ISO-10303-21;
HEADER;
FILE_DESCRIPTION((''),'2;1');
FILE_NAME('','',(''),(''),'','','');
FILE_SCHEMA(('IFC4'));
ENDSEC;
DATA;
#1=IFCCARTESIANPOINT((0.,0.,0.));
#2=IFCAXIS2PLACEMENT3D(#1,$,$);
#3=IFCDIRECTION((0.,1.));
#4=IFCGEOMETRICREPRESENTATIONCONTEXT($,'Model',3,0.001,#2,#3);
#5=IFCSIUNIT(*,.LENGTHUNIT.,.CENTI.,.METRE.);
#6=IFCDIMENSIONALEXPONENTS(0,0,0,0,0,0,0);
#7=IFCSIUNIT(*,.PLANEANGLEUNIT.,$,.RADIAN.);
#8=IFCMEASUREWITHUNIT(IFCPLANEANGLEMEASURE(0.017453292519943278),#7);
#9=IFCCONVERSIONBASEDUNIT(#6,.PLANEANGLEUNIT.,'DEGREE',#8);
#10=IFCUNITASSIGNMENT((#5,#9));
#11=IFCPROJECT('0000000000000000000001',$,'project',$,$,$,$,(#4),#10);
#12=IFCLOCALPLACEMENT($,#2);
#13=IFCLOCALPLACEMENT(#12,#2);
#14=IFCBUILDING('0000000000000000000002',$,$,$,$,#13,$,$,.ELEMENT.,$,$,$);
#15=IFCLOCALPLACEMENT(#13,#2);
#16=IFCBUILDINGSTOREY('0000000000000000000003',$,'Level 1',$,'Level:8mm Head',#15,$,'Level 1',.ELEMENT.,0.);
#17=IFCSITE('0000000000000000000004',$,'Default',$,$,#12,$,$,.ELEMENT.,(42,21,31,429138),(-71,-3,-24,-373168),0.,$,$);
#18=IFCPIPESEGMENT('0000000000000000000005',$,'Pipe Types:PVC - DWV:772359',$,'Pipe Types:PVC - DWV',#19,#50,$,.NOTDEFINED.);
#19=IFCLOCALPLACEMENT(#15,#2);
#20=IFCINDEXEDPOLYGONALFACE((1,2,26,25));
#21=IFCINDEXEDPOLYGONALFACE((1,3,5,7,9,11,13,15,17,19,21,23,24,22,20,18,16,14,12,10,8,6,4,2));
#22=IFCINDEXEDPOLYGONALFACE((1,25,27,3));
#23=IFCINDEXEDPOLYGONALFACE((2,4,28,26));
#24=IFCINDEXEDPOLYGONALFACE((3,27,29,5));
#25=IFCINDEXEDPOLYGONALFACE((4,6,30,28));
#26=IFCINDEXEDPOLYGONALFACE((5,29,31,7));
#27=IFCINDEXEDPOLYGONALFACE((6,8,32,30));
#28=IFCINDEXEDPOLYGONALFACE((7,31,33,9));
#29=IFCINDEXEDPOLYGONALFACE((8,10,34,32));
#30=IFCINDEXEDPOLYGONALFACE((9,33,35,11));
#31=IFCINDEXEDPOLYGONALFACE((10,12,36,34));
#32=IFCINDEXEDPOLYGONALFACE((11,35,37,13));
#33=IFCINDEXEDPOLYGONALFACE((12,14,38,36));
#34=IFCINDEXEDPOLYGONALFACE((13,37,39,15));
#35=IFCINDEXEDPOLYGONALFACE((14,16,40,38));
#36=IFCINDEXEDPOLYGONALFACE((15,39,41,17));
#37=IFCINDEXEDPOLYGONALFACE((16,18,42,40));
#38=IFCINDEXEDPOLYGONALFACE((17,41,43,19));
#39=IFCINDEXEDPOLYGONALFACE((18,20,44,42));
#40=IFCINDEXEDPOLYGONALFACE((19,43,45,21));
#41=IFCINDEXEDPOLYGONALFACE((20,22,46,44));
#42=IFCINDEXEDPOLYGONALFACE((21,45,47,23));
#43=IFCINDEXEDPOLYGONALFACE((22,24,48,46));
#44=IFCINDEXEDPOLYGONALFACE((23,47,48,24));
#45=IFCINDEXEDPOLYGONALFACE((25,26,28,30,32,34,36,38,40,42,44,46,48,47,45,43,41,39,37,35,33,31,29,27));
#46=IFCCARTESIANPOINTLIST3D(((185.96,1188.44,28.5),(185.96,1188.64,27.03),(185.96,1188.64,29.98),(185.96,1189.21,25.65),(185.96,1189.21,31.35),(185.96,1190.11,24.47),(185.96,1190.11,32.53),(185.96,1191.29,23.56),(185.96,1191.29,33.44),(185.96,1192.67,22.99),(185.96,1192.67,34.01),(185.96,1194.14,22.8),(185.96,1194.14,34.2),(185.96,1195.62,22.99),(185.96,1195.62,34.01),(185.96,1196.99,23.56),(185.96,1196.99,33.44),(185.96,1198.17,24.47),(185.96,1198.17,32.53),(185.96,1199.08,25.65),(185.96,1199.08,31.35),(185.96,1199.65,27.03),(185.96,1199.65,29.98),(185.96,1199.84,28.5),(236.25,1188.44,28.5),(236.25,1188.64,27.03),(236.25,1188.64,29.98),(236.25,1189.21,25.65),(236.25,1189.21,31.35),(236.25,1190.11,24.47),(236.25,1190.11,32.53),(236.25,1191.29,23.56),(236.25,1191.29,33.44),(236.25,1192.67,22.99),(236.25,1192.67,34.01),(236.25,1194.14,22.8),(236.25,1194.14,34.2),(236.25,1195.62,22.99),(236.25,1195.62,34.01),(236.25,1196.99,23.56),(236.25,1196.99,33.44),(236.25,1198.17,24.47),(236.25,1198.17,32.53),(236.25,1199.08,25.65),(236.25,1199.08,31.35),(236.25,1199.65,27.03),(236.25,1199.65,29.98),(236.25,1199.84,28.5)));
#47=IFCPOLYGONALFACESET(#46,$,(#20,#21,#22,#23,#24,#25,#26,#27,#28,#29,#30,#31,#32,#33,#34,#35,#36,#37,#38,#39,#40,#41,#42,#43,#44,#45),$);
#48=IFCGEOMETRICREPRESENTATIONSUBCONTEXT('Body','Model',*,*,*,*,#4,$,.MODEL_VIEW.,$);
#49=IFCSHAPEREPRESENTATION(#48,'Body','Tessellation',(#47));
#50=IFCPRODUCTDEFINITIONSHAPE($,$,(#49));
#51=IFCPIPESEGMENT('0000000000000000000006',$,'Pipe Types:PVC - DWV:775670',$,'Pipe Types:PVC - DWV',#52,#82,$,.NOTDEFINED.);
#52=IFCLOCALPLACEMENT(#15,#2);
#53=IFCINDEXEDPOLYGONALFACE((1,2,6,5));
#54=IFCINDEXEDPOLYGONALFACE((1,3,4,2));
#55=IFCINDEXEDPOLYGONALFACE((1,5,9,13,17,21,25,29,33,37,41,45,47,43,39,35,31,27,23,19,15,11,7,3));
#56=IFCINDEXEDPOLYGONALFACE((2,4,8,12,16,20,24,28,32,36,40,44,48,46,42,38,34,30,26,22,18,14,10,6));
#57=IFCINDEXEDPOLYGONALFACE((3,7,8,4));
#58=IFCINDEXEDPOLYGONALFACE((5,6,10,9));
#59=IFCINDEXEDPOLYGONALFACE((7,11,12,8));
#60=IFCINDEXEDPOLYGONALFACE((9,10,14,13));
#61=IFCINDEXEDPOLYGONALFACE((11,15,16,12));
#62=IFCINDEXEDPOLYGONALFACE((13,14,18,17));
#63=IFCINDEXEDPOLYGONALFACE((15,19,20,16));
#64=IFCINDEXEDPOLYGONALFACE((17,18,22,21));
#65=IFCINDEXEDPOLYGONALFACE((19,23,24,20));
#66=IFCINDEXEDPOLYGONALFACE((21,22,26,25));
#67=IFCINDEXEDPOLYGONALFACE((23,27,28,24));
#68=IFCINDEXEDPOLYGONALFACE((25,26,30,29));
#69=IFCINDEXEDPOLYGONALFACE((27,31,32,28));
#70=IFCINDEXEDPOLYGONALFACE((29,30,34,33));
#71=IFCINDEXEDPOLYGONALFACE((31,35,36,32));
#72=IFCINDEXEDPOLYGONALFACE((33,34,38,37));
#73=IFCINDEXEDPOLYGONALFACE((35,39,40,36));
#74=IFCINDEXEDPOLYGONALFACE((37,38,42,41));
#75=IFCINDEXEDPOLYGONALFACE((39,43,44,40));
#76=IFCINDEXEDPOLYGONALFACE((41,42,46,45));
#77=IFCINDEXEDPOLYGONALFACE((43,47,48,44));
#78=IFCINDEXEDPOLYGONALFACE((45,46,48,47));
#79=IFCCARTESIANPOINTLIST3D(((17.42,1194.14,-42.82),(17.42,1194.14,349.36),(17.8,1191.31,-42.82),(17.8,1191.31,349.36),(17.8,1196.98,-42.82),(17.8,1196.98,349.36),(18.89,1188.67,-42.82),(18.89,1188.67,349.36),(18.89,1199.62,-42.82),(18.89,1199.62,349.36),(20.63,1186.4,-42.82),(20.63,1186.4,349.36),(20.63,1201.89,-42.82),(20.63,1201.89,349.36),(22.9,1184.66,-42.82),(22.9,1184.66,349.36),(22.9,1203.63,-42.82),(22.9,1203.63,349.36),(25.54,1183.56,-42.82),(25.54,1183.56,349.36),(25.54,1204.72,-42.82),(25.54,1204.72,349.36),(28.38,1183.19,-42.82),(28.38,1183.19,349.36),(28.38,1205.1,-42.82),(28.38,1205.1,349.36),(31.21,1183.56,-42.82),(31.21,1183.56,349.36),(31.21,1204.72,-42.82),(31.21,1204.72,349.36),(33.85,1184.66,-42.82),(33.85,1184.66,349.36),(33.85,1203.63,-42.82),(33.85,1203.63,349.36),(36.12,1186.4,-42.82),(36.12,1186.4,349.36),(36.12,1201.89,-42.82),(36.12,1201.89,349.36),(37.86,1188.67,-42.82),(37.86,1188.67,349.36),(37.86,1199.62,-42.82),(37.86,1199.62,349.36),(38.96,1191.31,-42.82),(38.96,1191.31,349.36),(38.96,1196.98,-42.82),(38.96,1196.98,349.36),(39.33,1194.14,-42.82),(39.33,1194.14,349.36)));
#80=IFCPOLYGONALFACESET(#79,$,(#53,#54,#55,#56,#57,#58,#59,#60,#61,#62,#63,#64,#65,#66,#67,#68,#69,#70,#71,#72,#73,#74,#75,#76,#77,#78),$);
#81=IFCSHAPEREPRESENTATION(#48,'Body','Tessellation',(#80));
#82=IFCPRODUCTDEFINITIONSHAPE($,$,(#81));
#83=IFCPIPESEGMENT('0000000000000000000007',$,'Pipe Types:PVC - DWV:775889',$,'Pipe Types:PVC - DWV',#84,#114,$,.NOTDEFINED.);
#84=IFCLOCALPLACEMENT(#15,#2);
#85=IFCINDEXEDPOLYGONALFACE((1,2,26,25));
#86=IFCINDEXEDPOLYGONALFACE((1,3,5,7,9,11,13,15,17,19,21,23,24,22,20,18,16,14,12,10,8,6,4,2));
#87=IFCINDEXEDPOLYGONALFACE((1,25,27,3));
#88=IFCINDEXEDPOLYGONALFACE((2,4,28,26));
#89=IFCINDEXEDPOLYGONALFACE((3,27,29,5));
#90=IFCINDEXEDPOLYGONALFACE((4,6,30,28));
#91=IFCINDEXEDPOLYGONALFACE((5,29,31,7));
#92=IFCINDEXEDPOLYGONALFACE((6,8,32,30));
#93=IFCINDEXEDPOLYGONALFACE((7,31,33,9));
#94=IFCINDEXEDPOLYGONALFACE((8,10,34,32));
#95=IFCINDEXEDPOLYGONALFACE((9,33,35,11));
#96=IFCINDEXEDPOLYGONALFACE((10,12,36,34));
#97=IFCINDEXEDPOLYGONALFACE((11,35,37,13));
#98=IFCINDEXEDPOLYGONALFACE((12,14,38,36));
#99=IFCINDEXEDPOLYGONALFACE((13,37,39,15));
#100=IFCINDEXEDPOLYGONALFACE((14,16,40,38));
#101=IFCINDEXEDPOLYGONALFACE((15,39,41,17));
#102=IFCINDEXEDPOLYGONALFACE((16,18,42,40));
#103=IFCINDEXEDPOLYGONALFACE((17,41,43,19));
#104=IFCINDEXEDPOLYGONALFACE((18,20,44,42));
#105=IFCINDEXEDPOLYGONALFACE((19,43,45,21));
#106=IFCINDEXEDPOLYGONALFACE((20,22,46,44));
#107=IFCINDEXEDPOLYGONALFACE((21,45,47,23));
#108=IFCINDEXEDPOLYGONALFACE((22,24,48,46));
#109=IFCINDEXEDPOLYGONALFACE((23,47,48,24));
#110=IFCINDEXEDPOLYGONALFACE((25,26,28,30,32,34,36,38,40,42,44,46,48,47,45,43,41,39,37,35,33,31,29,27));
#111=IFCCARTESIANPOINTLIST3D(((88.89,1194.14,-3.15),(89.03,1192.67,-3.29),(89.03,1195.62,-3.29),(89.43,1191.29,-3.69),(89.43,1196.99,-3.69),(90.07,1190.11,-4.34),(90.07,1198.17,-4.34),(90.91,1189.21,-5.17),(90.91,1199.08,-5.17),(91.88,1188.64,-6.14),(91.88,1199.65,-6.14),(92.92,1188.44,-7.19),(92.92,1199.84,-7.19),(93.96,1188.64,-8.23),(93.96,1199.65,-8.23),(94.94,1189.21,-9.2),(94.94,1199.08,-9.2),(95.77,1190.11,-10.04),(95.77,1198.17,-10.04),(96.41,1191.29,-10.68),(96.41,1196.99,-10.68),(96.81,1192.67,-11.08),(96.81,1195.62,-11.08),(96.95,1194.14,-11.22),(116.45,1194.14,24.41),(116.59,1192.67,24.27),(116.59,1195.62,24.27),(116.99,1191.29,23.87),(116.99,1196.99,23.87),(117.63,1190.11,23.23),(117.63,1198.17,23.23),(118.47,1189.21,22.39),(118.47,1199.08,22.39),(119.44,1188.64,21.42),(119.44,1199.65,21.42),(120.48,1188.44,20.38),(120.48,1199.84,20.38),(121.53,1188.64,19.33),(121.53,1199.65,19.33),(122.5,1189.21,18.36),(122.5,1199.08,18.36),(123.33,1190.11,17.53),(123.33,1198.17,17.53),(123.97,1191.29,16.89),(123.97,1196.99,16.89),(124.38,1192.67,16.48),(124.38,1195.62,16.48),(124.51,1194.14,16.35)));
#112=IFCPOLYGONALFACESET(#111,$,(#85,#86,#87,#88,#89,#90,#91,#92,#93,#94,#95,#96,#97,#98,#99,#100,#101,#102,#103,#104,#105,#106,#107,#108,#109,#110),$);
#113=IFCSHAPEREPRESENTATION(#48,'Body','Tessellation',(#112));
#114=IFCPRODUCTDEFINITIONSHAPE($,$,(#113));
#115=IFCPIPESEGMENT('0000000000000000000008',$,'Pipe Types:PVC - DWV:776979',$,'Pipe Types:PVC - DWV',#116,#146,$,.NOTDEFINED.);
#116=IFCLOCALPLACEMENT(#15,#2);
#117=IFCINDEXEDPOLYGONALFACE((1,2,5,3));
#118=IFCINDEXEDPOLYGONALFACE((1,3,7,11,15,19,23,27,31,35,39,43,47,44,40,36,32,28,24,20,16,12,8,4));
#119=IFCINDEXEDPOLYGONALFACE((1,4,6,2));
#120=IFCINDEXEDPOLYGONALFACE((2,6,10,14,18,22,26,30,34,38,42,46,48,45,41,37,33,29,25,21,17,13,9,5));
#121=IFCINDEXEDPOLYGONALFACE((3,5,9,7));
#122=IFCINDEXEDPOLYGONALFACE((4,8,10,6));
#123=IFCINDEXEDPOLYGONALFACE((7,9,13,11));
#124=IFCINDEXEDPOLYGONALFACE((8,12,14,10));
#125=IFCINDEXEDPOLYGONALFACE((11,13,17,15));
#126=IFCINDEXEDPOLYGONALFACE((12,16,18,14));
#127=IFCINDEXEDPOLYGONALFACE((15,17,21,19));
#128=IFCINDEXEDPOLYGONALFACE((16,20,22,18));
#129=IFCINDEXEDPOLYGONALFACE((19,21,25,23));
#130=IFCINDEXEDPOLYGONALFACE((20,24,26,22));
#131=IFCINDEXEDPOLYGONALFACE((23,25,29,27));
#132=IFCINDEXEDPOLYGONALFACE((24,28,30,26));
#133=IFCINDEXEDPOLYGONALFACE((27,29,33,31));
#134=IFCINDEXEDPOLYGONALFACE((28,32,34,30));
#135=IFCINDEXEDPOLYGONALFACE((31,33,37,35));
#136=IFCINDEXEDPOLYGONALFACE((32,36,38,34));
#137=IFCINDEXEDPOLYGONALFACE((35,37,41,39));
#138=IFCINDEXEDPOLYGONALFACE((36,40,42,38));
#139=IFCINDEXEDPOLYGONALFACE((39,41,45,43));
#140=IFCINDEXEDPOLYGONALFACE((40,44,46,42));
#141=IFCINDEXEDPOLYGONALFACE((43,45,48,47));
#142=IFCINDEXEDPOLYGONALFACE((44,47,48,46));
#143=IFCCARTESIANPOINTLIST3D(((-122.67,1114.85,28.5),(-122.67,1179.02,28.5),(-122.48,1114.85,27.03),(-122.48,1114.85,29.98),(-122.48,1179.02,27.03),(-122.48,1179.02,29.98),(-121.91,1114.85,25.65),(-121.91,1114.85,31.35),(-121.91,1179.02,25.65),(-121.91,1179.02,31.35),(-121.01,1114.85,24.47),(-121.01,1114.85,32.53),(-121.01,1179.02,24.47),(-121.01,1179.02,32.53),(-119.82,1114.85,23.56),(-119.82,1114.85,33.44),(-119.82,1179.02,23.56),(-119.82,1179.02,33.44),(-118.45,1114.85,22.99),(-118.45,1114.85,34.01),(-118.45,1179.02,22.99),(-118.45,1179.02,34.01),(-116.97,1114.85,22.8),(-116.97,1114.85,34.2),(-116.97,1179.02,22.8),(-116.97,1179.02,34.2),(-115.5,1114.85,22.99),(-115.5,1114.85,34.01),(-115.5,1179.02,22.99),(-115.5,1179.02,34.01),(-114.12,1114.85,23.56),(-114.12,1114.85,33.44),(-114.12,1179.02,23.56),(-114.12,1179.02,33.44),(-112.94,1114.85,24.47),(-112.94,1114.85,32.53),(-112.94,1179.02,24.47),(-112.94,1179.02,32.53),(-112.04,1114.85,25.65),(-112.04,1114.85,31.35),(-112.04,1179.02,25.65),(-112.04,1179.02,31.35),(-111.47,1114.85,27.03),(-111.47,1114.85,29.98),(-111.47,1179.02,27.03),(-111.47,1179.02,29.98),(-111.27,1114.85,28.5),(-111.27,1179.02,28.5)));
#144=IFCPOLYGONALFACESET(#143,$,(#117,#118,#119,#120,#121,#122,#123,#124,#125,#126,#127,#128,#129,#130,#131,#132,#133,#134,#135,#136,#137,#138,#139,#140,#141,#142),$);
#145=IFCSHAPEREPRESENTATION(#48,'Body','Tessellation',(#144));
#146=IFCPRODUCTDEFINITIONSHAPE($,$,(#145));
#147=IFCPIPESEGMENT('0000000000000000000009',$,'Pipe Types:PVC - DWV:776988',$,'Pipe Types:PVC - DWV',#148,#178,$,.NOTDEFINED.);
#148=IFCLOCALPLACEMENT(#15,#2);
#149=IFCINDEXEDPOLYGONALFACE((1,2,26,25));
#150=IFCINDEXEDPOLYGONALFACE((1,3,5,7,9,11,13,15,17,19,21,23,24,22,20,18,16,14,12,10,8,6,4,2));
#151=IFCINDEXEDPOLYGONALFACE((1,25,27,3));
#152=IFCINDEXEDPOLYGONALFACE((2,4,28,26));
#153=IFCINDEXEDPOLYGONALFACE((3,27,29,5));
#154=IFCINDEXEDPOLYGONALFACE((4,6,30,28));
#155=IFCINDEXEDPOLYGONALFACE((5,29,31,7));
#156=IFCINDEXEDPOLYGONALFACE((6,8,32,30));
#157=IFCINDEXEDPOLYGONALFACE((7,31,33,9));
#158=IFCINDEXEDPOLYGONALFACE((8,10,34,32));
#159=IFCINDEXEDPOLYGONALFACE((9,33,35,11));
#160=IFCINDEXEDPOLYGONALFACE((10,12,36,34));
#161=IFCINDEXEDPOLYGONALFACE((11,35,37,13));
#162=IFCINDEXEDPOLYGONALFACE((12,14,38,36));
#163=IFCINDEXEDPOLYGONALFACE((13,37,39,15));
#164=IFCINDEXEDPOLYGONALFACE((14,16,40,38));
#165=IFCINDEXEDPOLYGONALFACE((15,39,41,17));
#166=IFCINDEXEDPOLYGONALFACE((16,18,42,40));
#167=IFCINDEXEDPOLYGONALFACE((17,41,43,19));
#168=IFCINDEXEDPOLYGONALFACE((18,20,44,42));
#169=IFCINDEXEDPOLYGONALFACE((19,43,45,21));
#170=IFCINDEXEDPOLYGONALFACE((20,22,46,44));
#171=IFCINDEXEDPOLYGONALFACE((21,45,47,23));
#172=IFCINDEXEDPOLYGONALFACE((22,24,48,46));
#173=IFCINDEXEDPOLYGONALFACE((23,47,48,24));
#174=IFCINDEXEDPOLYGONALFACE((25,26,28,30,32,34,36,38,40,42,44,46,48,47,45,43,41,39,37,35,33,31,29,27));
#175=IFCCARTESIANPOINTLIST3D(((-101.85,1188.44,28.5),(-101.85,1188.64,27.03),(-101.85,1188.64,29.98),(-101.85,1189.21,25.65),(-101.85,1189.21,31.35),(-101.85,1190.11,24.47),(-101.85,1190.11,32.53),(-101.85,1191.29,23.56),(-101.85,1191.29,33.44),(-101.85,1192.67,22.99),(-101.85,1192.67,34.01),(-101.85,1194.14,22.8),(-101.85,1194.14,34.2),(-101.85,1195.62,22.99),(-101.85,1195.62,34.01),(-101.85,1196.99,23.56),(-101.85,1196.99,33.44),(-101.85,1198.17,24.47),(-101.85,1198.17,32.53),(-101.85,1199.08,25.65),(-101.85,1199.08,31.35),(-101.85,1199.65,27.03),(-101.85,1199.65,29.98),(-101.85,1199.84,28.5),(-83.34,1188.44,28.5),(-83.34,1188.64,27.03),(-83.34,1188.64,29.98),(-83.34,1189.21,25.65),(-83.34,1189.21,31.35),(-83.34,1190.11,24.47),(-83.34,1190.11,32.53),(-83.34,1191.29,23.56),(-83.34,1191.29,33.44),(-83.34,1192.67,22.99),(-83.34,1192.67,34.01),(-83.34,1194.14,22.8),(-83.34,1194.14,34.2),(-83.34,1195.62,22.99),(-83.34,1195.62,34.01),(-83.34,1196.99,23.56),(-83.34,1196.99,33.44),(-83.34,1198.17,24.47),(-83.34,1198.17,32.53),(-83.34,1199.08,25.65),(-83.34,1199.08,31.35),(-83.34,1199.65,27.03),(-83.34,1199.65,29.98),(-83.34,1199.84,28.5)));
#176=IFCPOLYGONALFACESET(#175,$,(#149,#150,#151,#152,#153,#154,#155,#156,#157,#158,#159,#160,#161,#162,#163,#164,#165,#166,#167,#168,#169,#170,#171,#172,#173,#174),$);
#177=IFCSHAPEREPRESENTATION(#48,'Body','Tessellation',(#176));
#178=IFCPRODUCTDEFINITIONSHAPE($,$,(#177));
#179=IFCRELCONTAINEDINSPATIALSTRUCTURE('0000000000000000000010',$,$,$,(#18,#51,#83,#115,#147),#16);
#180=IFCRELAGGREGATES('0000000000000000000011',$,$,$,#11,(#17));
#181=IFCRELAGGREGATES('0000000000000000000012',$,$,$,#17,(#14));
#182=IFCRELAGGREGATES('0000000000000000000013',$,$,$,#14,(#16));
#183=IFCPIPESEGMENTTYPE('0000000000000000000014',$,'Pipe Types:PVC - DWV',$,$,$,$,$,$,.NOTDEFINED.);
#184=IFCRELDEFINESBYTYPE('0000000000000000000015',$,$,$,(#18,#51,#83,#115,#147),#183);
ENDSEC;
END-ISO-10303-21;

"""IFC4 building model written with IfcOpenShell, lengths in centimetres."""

from ifc_helpers import new_model, entity, si_unit, converted_unit, direction, frame, origin, place, context, subcontext, project, spatial, arc, indexed_curve, outline, extrude, type_object, element, save


model = new_model("IFC4")

# Units and contexts
model_context = context("Model", 3, precision=0.001, world=origin(), true_north=direction((0.0, 1.0)))
body_context = subcontext(model_context, "Body", "Model", "MODEL_VIEW")
ifc_project = project(units=[si_unit("LENGTHUNIT", "METRE", prefix="CENTI"), converted_unit("PLANEANGLEUNIT", "DEGREE", entity("IfcPlaneAngleMeasure", 0.017453292519943278), si_unit("PLANEANGLEUNIT", "RADIAN"), dimensions=[0, 0, 0, 0, 0, 0, 0])], contexts=[model_context])

# Site, building, storey
site_placement = place(None, origin())
site = spatial("IfcSite", under=ifc_project, at=site_placement, Name="Default", CompositionType="ELEMENT", RefLatitude=(42, 21, 31, 429138), RefLongitude=(-71, -3, -24, -373168), RefElevation=0.0)
building_placement = place(site_placement, origin())
building = spatial("IfcBuilding", under=site, at=building_placement, CompositionType="ELEMENT")
storey_placement = place(building_placement, origin())
storey = spatial("IfcBuildingStorey", under=building, at=storey_placement, Name="Level 1", ObjectType="Level:8mm Head", LongName="Level 1", CompositionType="ELEMENT", Elevation=0.0)

# Pipe segments
pipe_segment_type = type_object("IfcPipeSegmentType", Name="Pipe Types:PVC - DWV", PredefinedType="NOTDEFINED")
pipe_segment_1_placement = place(storey_placement, origin())
element("IfcPipeSegment", 1, at=pipe_segment_1_placement, inside=storey, type_object=pipe_segment_type, Name="Pipe Types:PVC - DWV:772359", ObjectType="Pipe Types:PVC - DWV", PredefinedType="NOTDEFINED", context=body_context, shape_type="SweptSolid", body=[
    extrude(outline(indexed_curve([(5.7, 0.0), (4.03, 4.03), (0.0, 5.7), (-4.03, 4.03), (-5.7, 0.0), (-4.03, -4.03), (0.0, -5.7), (4.03, -4.03)], segments=[arc(1, 2, 3), arc(3, 4, 5), arc(5, 6, 7), arc(7, 8, 1)], self_intersect=False)), frame((185.96, 1194.14, 28.5), z_axis=(1.0, 0.0, 0.0), x_axis=(0.0, 1.0, 0.0)), (0.0, 0.0, 1.0), 50.29),
])
pipe_segment_2_placement = place(storey_placement, origin())
element("IfcPipeSegment", 2, at=pipe_segment_2_placement, inside=storey, type_object=pipe_segment_type, Name="Pipe Types:PVC - DWV:775670", ObjectType="Pipe Types:PVC - DWV", PredefinedType="NOTDEFINED", context=body_context, shape_type="SweptSolid", body=[
    extrude(outline(indexed_curve([(10.95, 0.0), (7.75, 7.75), (0.0, 10.95), (-7.75, 7.75), (-10.95, 0.0), (-7.75, -7.75), (0.0, -10.95), (7.75, -7.75)], segments=[arc(1, 2, 3), arc(3, 4, 5), arc(5, 6, 7), arc(7, 8, 1)], self_intersect=False)), frame((28.38, 1194.14, -42.82), z_axis=(0.0, 0.0, 1.0), x_axis=(-1.0, 0.0, 0.0)), (0.0, 0.0, 1.0), 392.18),
])
pipe_segment_3_placement = place(storey_placement, origin())
element("IfcPipeSegment", 3, at=pipe_segment_3_placement, inside=storey, type_object=pipe_segment_type, Name="Pipe Types:PVC - DWV:775889", ObjectType="Pipe Types:PVC - DWV", PredefinedType="NOTDEFINED", context=body_context, shape_type="SweptSolid", body=[
    extrude(outline(indexed_curve([(5.7, 0.0), (4.03, 4.03), (0.0, 5.7), (-4.03, 4.03), (-5.7, 0.0), (-4.03, -4.03), (0.0, -5.7), (4.03, -4.03)], segments=[arc(1, 2, 3), arc(3, 4, 5), arc(5, 6, 7), arc(7, 8, 1)], self_intersect=False)), frame((92.92, 1194.14, -7.19), z_axis=(0.707107, 0.0, 0.707107), x_axis=(0.0, -1.0, 0.0)), (0.0, 0.0, 1.0), 38.98),
])
pipe_segment_4_placement = place(storey_placement, origin())
element("IfcPipeSegment", 4, at=pipe_segment_4_placement, inside=storey, type_object=pipe_segment_type, Name="Pipe Types:PVC - DWV:776979", ObjectType="Pipe Types:PVC - DWV", PredefinedType="NOTDEFINED", context=body_context, shape_type="SweptSolid", body=[
    extrude(outline(indexed_curve([(5.7, 0.0), (4.03, 4.03), (0.0, 5.7), (-4.03, 4.03), (-5.7, 0.0), (-4.03, -4.03), (0.0, -5.7), (4.03, -4.03)], segments=[arc(1, 2, 3), arc(3, 4, 5), arc(5, 6, 7), arc(7, 8, 1)], self_intersect=False)), frame((-116.97, 1114.85, 28.5), z_axis=(0.0, 1.0, 0.0), x_axis=(-1.0, 0.0, 0.0)), (0.0, 0.0, 1.0), 64.18),
])
pipe_segment_5_placement = place(storey_placement, origin())
element("IfcPipeSegment", 5, at=pipe_segment_5_placement, inside=storey, type_object=pipe_segment_type, Name="Pipe Types:PVC - DWV:776988", ObjectType="Pipe Types:PVC - DWV", PredefinedType="NOTDEFINED", context=body_context, shape_type="SweptSolid", body=[
    extrude(outline(indexed_curve([(5.7, 0.0), (4.03, 4.03), (0.0, 5.7), (-4.03, 4.03), (-5.7, 0.0), (-4.03, -4.03), (0.0, -5.7), (4.03, -4.03)], segments=[arc(1, 2, 3), arc(3, 4, 5), arc(5, 6, 7), arc(7, 8, 1)], self_intersect=False)), frame((-101.85, 1194.14, 28.5), z_axis=(1.0, 0.0, 0.0), x_axis=(0.0, 1.0, 0.0)), (0.0, 0.0, 1.0), 18.51),
])

save(model, "model.ifc")
